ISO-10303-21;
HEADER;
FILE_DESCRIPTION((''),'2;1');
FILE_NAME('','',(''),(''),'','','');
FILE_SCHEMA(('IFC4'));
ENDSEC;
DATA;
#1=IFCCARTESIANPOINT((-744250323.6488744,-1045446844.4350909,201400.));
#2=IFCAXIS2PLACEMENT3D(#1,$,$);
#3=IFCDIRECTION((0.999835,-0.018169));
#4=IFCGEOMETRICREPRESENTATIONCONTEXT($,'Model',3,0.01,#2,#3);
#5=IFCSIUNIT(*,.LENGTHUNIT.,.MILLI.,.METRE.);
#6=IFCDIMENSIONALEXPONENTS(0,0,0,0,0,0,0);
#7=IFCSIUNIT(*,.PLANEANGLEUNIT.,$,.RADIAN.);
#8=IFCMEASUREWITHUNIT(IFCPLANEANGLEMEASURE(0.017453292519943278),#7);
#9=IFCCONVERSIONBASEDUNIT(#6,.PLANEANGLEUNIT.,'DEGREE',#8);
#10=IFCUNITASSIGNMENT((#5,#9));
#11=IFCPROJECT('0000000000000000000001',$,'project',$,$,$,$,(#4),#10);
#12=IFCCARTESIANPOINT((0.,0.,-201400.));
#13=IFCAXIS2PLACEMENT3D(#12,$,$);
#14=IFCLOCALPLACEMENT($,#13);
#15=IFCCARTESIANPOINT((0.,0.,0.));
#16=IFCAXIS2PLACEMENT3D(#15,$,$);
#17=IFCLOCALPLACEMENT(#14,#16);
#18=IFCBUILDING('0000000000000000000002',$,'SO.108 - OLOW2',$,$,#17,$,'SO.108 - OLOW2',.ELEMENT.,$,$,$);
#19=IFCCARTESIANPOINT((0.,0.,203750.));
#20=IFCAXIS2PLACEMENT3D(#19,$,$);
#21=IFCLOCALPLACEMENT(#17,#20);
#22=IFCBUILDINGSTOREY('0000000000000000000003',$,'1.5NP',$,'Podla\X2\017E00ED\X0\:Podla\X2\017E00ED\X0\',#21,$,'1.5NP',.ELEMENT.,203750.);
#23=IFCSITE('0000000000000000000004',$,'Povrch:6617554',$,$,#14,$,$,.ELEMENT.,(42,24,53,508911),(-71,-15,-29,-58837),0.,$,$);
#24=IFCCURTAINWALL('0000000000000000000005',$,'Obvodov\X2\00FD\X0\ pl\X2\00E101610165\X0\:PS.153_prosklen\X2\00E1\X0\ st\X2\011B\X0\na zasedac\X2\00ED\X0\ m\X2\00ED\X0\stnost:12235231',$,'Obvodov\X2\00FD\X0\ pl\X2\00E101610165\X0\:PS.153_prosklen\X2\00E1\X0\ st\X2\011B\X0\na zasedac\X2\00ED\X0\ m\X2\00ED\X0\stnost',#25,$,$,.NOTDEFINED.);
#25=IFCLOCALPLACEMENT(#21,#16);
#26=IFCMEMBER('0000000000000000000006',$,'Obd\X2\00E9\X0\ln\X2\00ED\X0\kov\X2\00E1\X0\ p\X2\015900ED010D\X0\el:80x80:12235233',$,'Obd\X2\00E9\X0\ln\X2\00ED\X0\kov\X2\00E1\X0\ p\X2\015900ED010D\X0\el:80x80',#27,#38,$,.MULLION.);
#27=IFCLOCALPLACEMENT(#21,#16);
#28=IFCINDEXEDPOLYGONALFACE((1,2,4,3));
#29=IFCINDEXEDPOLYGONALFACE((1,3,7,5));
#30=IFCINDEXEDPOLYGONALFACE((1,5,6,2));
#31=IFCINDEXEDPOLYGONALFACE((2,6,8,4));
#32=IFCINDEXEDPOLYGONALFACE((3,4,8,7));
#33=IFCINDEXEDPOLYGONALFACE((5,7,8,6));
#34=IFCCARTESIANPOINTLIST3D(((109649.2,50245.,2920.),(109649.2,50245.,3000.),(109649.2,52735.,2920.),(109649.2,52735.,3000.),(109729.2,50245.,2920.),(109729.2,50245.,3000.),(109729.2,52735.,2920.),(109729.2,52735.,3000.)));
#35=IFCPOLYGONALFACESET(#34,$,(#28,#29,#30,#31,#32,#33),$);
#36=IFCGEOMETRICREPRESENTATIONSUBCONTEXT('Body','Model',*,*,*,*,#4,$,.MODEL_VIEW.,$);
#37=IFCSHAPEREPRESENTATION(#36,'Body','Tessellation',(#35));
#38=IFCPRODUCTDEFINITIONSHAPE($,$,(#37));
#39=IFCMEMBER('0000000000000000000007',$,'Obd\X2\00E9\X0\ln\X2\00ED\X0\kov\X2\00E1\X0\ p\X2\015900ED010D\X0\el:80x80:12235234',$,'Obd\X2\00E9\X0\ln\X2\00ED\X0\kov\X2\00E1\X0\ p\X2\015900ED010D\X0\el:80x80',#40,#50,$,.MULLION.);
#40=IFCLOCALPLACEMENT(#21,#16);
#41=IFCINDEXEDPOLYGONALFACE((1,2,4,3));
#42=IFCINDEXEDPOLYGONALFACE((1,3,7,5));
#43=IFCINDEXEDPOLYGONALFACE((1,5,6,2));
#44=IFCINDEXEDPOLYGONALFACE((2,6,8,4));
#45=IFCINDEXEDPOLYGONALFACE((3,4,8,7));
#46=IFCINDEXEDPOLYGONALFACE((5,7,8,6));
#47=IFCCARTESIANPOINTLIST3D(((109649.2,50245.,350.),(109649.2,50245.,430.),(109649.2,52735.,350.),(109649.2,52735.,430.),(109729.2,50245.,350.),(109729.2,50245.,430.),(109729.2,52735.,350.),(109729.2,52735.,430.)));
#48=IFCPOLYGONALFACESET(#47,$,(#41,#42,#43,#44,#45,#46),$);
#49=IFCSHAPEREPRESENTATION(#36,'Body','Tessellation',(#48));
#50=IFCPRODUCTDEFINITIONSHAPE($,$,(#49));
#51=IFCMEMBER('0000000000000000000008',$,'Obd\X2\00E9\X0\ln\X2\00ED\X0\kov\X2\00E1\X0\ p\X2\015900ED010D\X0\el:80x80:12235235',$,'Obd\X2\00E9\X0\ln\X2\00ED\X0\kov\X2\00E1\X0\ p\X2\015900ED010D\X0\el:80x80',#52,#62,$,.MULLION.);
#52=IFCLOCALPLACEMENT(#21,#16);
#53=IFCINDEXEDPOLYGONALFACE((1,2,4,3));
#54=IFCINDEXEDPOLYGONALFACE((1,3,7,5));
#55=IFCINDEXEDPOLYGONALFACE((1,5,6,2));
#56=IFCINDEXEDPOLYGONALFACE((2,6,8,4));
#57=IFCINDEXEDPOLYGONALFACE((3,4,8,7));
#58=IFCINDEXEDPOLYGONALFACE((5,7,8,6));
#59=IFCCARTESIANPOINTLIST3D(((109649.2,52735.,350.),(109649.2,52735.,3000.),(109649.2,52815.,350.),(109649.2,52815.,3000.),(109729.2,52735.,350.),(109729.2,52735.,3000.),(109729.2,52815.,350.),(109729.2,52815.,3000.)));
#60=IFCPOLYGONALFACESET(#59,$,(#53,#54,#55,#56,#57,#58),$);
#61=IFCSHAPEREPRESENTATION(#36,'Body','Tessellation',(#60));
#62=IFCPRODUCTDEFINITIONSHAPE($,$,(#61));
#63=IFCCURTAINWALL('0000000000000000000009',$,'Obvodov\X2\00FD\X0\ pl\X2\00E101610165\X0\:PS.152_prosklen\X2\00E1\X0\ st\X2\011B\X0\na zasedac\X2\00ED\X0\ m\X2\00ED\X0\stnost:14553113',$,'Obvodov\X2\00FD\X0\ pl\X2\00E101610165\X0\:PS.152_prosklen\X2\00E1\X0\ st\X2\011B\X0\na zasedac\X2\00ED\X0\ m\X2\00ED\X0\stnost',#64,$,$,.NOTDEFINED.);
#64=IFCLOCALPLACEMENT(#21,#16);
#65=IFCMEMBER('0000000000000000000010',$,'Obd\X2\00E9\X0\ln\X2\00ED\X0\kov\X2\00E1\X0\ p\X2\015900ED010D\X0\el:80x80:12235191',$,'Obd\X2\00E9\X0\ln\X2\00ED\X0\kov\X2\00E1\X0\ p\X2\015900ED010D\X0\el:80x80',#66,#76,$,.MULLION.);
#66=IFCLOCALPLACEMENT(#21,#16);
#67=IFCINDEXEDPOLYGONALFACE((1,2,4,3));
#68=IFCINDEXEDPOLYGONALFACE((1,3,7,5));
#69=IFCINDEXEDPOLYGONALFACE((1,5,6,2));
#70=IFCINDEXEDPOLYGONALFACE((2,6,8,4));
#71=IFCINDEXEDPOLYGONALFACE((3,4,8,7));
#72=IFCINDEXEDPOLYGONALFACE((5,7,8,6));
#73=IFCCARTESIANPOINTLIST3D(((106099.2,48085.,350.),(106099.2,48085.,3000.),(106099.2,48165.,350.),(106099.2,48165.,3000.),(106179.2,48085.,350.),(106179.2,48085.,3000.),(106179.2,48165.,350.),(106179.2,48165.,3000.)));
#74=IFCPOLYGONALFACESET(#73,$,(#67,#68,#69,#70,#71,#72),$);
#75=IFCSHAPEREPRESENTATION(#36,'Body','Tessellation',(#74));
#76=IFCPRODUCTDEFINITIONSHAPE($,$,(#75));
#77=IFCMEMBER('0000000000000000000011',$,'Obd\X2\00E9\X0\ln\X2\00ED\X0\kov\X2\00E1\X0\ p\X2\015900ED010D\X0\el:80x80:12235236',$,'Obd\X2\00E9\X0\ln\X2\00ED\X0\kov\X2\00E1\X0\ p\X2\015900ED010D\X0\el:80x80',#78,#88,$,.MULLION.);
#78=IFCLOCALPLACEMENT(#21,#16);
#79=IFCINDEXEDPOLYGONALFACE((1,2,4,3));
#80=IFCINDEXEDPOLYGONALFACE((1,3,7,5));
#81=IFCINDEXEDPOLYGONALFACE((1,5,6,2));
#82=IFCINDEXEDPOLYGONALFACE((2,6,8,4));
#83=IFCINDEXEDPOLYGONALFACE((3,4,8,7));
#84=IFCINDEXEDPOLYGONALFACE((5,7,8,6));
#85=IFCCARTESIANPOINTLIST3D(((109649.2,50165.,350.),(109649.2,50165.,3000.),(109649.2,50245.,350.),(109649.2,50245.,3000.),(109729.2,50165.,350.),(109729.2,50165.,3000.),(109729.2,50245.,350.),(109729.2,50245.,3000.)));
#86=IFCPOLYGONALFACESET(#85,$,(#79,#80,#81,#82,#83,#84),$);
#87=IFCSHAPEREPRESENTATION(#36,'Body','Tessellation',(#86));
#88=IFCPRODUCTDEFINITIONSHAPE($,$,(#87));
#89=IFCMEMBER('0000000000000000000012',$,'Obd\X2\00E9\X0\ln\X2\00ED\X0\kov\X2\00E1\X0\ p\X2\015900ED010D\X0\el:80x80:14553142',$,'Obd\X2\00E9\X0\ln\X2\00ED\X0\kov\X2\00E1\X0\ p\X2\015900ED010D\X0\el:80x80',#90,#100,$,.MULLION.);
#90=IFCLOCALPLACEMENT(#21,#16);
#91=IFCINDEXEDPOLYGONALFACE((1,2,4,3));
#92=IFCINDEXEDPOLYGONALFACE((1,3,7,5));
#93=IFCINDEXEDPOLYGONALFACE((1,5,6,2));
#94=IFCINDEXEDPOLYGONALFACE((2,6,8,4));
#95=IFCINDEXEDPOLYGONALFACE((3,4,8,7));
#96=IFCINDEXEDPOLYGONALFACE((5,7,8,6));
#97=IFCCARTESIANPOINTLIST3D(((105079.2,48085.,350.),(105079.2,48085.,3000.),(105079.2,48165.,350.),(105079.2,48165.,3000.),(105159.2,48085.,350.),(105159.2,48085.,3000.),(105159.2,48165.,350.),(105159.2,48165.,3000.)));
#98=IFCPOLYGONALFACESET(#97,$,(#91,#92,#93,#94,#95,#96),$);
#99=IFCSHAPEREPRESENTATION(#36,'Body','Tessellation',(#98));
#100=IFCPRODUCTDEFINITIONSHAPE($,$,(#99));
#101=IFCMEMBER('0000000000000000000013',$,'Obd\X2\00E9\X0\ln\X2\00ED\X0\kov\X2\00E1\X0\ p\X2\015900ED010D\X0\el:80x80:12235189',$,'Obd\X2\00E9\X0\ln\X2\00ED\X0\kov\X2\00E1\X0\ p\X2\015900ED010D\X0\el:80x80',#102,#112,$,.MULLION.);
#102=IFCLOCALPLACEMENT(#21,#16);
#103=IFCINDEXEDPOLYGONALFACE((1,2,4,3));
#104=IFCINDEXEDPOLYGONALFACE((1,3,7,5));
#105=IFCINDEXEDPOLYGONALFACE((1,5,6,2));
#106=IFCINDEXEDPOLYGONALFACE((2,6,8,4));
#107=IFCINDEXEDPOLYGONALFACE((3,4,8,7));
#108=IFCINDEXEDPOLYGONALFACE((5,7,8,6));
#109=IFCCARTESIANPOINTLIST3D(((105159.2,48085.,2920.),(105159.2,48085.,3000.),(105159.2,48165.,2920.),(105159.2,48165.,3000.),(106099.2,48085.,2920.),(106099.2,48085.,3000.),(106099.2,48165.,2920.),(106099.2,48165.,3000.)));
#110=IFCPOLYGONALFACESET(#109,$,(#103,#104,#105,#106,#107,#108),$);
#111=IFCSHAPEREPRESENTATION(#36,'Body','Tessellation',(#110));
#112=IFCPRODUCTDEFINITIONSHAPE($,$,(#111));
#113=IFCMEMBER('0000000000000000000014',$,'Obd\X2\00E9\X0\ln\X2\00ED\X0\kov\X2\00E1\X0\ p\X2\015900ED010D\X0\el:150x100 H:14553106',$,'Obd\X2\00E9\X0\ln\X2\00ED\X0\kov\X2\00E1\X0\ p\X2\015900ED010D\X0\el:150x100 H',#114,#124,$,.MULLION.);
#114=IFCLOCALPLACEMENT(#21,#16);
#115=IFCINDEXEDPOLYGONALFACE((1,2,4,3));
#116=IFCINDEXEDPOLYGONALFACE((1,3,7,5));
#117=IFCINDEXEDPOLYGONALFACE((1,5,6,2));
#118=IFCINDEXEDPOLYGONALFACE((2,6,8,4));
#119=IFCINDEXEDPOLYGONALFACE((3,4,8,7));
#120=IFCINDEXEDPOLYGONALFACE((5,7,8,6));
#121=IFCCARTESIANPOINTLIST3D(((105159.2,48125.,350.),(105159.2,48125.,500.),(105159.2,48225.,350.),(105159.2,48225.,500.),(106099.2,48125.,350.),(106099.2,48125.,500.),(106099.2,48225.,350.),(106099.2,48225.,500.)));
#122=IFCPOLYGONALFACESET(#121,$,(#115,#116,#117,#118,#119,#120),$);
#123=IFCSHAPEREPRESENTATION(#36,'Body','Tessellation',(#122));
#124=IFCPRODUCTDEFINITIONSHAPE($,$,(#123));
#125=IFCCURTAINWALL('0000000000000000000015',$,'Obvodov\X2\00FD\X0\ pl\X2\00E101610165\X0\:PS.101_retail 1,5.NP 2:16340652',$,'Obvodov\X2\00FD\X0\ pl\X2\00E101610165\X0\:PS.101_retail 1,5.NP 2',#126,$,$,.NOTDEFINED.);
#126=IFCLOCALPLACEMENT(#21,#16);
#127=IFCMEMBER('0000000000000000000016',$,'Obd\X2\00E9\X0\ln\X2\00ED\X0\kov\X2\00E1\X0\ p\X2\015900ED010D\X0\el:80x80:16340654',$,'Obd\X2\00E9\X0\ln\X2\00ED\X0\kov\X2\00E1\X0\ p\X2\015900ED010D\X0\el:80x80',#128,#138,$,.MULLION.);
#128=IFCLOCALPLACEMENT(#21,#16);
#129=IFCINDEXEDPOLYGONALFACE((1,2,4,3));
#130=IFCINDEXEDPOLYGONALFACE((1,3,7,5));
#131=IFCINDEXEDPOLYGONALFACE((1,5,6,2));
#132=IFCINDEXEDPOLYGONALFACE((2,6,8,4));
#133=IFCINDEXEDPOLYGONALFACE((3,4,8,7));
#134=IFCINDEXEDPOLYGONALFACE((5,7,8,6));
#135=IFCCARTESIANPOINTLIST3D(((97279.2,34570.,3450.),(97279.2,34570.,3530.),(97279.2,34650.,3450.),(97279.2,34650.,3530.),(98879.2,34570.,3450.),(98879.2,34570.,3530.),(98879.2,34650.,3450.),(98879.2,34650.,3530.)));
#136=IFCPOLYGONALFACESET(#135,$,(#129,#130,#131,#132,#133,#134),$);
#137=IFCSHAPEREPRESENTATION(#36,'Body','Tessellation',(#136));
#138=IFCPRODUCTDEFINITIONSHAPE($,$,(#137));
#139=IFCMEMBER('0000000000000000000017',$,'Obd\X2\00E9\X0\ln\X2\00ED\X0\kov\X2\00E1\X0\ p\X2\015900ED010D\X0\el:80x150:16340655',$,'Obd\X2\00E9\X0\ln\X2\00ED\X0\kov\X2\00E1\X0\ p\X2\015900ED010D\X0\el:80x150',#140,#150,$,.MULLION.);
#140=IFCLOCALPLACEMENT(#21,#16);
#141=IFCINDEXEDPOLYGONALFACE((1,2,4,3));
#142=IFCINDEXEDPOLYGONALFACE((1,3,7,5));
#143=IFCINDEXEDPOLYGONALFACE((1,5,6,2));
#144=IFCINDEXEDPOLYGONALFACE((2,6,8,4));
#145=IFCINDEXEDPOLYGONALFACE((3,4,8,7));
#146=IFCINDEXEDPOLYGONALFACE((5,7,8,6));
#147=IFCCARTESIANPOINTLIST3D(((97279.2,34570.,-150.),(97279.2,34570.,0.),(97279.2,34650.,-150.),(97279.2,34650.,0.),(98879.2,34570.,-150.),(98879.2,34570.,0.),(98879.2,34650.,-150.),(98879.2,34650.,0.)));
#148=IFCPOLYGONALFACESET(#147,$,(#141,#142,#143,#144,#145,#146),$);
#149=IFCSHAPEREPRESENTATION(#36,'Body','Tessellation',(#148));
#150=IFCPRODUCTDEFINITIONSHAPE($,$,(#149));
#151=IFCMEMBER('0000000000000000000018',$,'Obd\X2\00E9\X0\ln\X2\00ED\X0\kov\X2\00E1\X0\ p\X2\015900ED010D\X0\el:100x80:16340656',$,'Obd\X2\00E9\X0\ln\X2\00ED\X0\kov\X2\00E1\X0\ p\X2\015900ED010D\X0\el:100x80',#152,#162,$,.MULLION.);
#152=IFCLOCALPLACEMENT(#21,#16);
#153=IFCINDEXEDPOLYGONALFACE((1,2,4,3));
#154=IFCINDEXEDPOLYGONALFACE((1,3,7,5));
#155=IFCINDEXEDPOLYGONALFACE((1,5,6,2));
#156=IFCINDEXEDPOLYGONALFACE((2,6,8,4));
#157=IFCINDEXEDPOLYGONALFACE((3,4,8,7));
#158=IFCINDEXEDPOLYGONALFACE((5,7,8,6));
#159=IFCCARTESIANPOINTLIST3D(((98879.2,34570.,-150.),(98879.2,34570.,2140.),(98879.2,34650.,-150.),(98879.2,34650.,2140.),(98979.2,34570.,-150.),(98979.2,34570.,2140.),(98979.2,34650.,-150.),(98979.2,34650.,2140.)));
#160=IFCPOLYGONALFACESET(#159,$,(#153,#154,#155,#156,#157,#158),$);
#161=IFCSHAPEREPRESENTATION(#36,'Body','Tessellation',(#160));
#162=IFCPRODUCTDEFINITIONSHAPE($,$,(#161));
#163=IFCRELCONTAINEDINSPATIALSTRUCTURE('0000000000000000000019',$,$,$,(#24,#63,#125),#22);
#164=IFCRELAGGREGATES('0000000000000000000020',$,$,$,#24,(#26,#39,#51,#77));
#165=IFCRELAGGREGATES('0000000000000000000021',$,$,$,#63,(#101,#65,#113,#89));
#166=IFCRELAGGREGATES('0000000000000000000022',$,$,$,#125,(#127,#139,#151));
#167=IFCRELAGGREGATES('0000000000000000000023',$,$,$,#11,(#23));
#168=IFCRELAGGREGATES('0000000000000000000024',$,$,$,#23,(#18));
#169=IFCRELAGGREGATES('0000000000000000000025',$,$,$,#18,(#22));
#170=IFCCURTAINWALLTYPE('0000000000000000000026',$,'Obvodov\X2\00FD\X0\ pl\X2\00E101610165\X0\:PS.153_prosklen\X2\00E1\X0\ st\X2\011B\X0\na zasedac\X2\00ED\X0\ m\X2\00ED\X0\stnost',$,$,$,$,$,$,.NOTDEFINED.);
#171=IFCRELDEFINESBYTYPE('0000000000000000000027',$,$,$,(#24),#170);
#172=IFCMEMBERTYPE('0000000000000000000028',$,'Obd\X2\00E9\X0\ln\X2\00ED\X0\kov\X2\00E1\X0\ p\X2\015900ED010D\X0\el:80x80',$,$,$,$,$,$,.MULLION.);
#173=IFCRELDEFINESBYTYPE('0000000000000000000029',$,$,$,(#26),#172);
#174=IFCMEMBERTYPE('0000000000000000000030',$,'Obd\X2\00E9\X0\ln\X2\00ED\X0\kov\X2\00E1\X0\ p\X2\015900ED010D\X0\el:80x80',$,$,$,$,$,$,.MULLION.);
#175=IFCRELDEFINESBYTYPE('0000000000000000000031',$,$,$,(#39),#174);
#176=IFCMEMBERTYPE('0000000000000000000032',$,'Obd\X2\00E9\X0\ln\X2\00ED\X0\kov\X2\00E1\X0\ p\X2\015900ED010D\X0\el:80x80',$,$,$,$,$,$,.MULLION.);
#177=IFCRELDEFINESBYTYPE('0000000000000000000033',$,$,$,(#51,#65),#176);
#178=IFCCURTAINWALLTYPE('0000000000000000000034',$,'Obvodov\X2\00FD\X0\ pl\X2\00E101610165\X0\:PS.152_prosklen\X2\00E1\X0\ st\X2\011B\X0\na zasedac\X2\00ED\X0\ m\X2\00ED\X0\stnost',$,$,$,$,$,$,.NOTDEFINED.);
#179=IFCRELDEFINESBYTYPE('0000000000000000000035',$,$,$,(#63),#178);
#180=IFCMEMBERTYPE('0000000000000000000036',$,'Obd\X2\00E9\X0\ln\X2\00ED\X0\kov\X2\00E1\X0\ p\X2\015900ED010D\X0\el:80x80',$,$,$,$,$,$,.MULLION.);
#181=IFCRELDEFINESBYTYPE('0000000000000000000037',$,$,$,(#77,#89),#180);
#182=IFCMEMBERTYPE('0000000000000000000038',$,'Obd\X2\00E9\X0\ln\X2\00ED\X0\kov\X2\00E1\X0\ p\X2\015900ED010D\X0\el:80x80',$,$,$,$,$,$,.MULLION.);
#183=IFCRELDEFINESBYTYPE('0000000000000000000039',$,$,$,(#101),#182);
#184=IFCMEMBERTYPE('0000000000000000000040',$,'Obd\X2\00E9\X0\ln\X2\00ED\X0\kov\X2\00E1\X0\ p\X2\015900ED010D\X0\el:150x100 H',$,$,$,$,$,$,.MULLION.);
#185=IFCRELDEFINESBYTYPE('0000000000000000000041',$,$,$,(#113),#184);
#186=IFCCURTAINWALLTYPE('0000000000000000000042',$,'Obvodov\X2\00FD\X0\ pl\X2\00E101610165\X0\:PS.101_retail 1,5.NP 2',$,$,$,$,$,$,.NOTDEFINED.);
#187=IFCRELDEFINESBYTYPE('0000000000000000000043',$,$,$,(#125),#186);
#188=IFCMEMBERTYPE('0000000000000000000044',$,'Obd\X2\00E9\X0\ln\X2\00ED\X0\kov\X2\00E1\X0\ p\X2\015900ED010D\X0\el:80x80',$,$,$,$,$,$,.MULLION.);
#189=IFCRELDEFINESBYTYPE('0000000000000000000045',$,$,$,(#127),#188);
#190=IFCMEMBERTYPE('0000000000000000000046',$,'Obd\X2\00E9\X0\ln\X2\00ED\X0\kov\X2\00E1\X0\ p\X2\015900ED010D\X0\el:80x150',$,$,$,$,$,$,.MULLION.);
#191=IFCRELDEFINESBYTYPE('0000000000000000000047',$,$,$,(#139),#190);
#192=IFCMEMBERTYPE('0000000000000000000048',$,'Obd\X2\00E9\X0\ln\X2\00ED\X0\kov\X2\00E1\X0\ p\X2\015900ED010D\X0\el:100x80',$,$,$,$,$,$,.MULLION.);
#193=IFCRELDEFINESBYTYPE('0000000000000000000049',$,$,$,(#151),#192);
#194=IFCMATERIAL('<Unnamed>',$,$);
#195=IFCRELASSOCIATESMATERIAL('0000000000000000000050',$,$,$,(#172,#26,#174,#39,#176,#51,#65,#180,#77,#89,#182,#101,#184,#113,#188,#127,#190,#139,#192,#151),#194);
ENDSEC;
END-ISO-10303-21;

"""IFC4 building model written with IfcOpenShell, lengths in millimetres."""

from ifc_helpers import new_model, entity, si_unit, converted_unit, direction, frame, origin, place, context, subcontext, project, spatial, indexed_curve, outline, extrude, source, transform, mapped, material, type_object, type_shapes, element, aggregate, save


model = new_model("IFC4")

# Units and contexts
model_context = context("Model", 3, precision=0.01, world=frame((-744250323.6488744, -1045446844.4350909, 201400.0)), true_north=direction((0.999835, -0.018169)))
body_context = subcontext(model_context, "Body", "Model", "MODEL_VIEW")
ifc_project = project(units=[si_unit("LENGTHUNIT", "METRE", prefix="MILLI"), converted_unit("PLANEANGLEUNIT", "DEGREE", entity("IfcPlaneAngleMeasure", 0.017453292519943278), si_unit("PLANEANGLEUNIT", "RADIAN"), dimensions=[0, 0, 0, 0, 0, 0, 0])], contexts=[model_context])

# Site, building, storey
site_placement = place(None, frame((0.0, 0.0, -201400.0)))
site = spatial("IfcSite", under=ifc_project, at=site_placement, Name="Povrch:6617554", CompositionType="ELEMENT", RefLatitude=(42, 24, 53, 508911), RefLongitude=(-71, -15, -29, -58837), RefElevation=0.0)
building_placement = place(site_placement, origin())
building = spatial("IfcBuilding", under=site, at=building_placement, Name="SO.108 - OLOW2", LongName="SO.108 - OLOW2", CompositionType="ELEMENT")
storey_placement = place(building_placement, frame((0.0, 0.0, 203750.0)))
storey = spatial("IfcBuildingStorey", under=building, at=storey_placement, Name="1.5NP", ObjectType="Podlaží:Podlaží", LongName="1.5NP", CompositionType="ELEMENT", Elevation=203750.0)

# Curtain wall, members
curtain_wall_type_1 = type_object("IfcCurtainWallType", Name="Obvodový plášť:PS.153_prosklená stěna zasedací místnost", PredefinedType="NOTDEFINED")
curtain_wall_1_placement = place(storey_placement, frame((0.0, 0.0, -203750.0)))
curtain_wall_1 = element("IfcCurtainWall", 1, at=curtain_wall_1_placement, inside=storey, type_object=curtain_wall_type_1, Name="Obvodový plášť:PS.153_prosklená stěna zasedací místnost:12235231", ObjectType="Obvodový plášť:PS.153_prosklená stěna zasedací místnost", PredefinedType="NOTDEFINED")
ifc_material_1 = material(Name="<Unnamed>")
member_type_1 = type_object("IfcMemberType", Name="Obdélníková příčel:80x80", PredefinedType="MULLION", material=ifc_material_1)
shared_shape_1 = source(origin(), body_context, "Body", "SweptSolid", [
    extrude(outline(indexed_curve([(-40.0, -40.0), (40.0, -40.0), (40.0, 40.0), (-40.0, 40.0), (-40.0, -40.0)], self_intersect=False)), frame((-40.0, 0.0, -2490.0), z_axis=(0.0, 0.0, 1.0), x_axis=(-1.0, 0.0, 0.0)), (0.0, 0.0, 1.0), 2490.0),
])
type_shapes(member_type_1, [shared_shape_1])
member_1_placement = place(curtain_wall_1_placement, frame((109689.2, 52735.0, 206750.0), z_axis=(0.0, 1.0, 0.0), x_axis=(0.0, 0.0, 1.0)))
member_1 = element("IfcMember", 2, at=member_1_placement, type_object=member_type_1, material=ifc_material_1, Name="Obdélníková příčel:80x80:12235233", ObjectType="Obdélníková příčel:80x80", PredefinedType="MULLION", context=body_context, shape_type="MappedRepresentation", body=[
    mapped(shared_shape_1, transform((0.0, 0.0, 0.0), scale=1.0)),
])
member_type_2 = type_object("IfcMemberType", Name="Obdélníková příčel:80x80", PredefinedType="MULLION", material=ifc_material_1)
shared_shape_2 = source(origin(), body_context, "Body", "SweptSolid", [
    extrude(outline(indexed_curve([(-40.0, -40.0), (40.0, -40.0), (40.0, 40.0), (-40.0, 40.0), (-40.0, -40.0)], self_intersect=False)), frame((-40.0, 0.0, -2490.0), z_axis=(0.0, 0.0, 1.0), x_axis=(-1.0, 0.0, 0.0)), (0.0, 0.0, 1.0), 2490.0),
])
type_shapes(member_type_2, [shared_shape_2])
member_2_placement = place(curtain_wall_1_placement, frame((109689.2, 50245.0, 204100.0), z_axis=(0.0, -1.0, 0.0), x_axis=(0.0, 0.0, -1.0)))
member_2 = element("IfcMember", 3, at=member_2_placement, type_object=member_type_2, material=ifc_material_1, Name="Obdélníková příčel:80x80:12235234", ObjectType="Obdélníková příčel:80x80", PredefinedType="MULLION", context=body_context, shape_type="MappedRepresentation", body=[
    mapped(shared_shape_2, transform((0.0, 0.0, 0.0), scale=1.0)),
])
member_type_3 = type_object("IfcMemberType", Name="Obdélníková příčel:80x80", PredefinedType="MULLION", material=ifc_material_1)
shared_shape_3 = source(origin(), body_context, "Body", "SweptSolid", [
    extrude(outline(indexed_curve([(-40.0, -40.0), (40.0, -40.0), (40.0, 40.0), (-40.0, 40.0), (-40.0, -40.0)], self_intersect=False)), frame((-40.0, 0.0, -2650.0), z_axis=(0.0, 0.0, 1.0), x_axis=(-1.0, 0.0, 0.0)), (0.0, 0.0, 1.0), 2650.0),
])
type_shapes(member_type_3, [shared_shape_3])
member_3_placement = place(curtain_wall_1_placement, frame((109689.2, 52815.0, 204100.0), z_axis=(0.0, 0.0, -1.0), x_axis=(0.0, 1.0, 0.0)))
member_3 = element("IfcMember", 4, at=member_3_placement, type_object=member_type_3, material=ifc_material_1, Name="Obdélníková příčel:80x80:12235235", ObjectType="Obdélníková příčel:80x80", PredefinedType="MULLION", context=body_context, shape_type="MappedRepresentation", body=[
    mapped(shared_shape_3, transform((0.0, 0.0, 0.0), scale=1.0)),
])

# Curtain wall, member
curtain_wall_type_2 = type_object("IfcCurtainWallType", Name="Obvodový plášť:PS.152_prosklená stěna zasedací místnost", PredefinedType="NOTDEFINED")
curtain_wall_2_placement = place(storey_placement, frame((0.0, 0.0, -203750.0)))
curtain_wall_2 = element("IfcCurtainWall", 5, at=curtain_wall_2_placement, inside=storey, type_object=curtain_wall_type_2, Name="Obvodový plášť:PS.152_prosklená stěna zasedací místnost:14553113", ObjectType="Obvodový plášť:PS.152_prosklená stěna zasedací místnost", PredefinedType="NOTDEFINED")
member_4_placement = place(curtain_wall_2_placement, frame((106179.2, 48125.0, 204100.0), z_axis=(0.0, 0.0, -1.0), x_axis=(1.0, 0.0, 0.0)))
member_4 = element("IfcMember", 6, at=member_4_placement, type_object=member_type_3, material=ifc_material_1, Name="Obdélníková příčel:80x80:12235191", ObjectType="Obdélníková příčel:80x80", PredefinedType="MULLION", context=body_context, shape_type="MappedRepresentation", body=[
    mapped(shared_shape_3, transform((0.0, 0.0, 0.0), scale=1.0)),
])

# Members
member_type_4 = type_object("IfcMemberType", Name="Obdélníková příčel:80x80", PredefinedType="MULLION", material=ifc_material_1)
shared_shape_4 = source(origin(), body_context, "Body", "SweptSolid", [
    extrude(outline(indexed_curve([(-40.0, -40.0), (40.0, -40.0), (40.0, 40.0), (-40.0, 40.0), (-40.0, -40.0)], self_intersect=False)), frame((-40.0, 0.0, -2650.0), z_axis=(0.0, 0.0, 1.0), x_axis=(-1.0, 0.0, 0.0)), (0.0, 0.0, 1.0), 2650.0),
])
type_shapes(member_type_4, [shared_shape_4])
member_5_placement = place(curtain_wall_1_placement, frame((109689.2, 50165.0, 206750.0), z_axis=(0.0, 0.0, 1.0), x_axis=(0.0, -1.0, 0.0)))
member_5 = element("IfcMember", 7, at=member_5_placement, type_object=member_type_4, material=ifc_material_1, Name="Obdélníková příčel:80x80:12235236", ObjectType="Obdélníková příčel:80x80", PredefinedType="MULLION", context=body_context, shape_type="MappedRepresentation", body=[
    mapped(shared_shape_4, transform((0.0, 0.0, 0.0), scale=1.0)),
])
member_6_placement = place(curtain_wall_2_placement, frame((105079.2, 48125.0, 206750.0), z_axis=(0.0, 0.0, 1.0), x_axis=(-1.0, 0.0, 0.0)))
member_6 = element("IfcMember", 8, at=member_6_placement, type_object=member_type_4, material=ifc_material_1, Name="Obdélníková příčel:80x80:14553142", ObjectType="Obdélníková příčel:80x80", PredefinedType="MULLION", context=body_context, shape_type="MappedRepresentation", body=[
    mapped(shared_shape_4, transform((0.0, 0.0, 0.0), scale=1.0)),
])
member_type_5 = type_object("IfcMemberType", Name="Obdélníková příčel:80x80", PredefinedType="MULLION", material=ifc_material_1)
shared_shape_5 = source(origin(), body_context, "Body", "SweptSolid", [
    extrude(outline(indexed_curve([(-40.0, -40.0), (40.0, -40.0), (40.0, 40.0), (-40.0, 40.0), (-40.0, -40.0)], self_intersect=False)), frame((-40.0, 0.0, -940.0), z_axis=(0.0, 0.0, 1.0), x_axis=(-1.0, 0.0, 0.0)), (0.0, 0.0, 1.0), 940.0),
])
type_shapes(member_type_5, [shared_shape_5])
member_7_placement = place(curtain_wall_2_placement, frame((106099.2, 48125.0, 206750.0), z_axis=(1.0, 0.0, 0.0), x_axis=(0.0, 0.0, 1.0)))
member_7 = element("IfcMember", 9, at=member_7_placement, type_object=member_type_5, material=ifc_material_1, Name="Obdélníková příčel:80x80:12235189", ObjectType="Obdélníková příčel:80x80", PredefinedType="MULLION", context=body_context, shape_type="MappedRepresentation", body=[
    mapped(shared_shape_5, transform((0.0, 0.0, 0.0), scale=1.0)),
])
member_type_6 = type_object("IfcMemberType", Name="Obdélníková příčel:150x100 H", PredefinedType="MULLION", material=ifc_material_1)
shared_shape_6 = source(origin(), body_context, "Body", "SweptSolid", [
    extrude(outline(indexed_curve([(-75.0, -50.0), (75.0, -50.0), (75.0, 50.0), (-75.0, 50.0), (-75.0, -50.0)], self_intersect=False)), frame((-75.0, -50.0, -940.0), z_axis=(0.0, 0.0, 1.0), x_axis=(-1.0, 0.0, 0.0)), (0.0, 0.0, 1.0), 940.0),
])
type_shapes(member_type_6, [shared_shape_6])
member_8_placement = place(curtain_wall_2_placement, frame((105159.2, 48125.0, 204100.0), z_axis=(-1.0, 0.0, 0.0), x_axis=(0.0, 0.0, -1.0)))
member_8 = element("IfcMember", 10, at=member_8_placement, type_object=member_type_6, material=ifc_material_1, Name="Obdélníková příčel:150x100 H:14553106", ObjectType="Obdélníková příčel:150x100 H", PredefinedType="MULLION", context=body_context, shape_type="MappedRepresentation", body=[
    mapped(shared_shape_6, transform((0.0, 0.0, 0.0), scale=1.0)),
])

# Curtain wall, members
curtain_wall_type_3 = type_object("IfcCurtainWallType", Name="Obvodový plášť:PS.101_retail 1,5.NP 2", PredefinedType="NOTDEFINED")
curtain_wall_3_placement = place(storey_placement, frame((0.0, 0.0, -203750.0)))
curtain_wall_3 = element("IfcCurtainWall", 11, at=curtain_wall_3_placement, inside=storey, type_object=curtain_wall_type_3, Name="Obvodový plášť:PS.101_retail 1,5.NP 2:16340652", ObjectType="Obvodový plášť:PS.101_retail 1,5.NP 2", PredefinedType="NOTDEFINED")
member_type_7 = type_object("IfcMemberType", Name="Obdélníková příčel:80x80", PredefinedType="MULLION", material=ifc_material_1)
shared_shape_7 = source(origin(), body_context, "Body", "SweptSolid", [
    extrude(outline(indexed_curve([(-40.0, -40.0), (40.0, -40.0), (40.0, 40.0), (-40.0, 40.0), (-40.0, -40.0)], self_intersect=False)), frame((-40.0, 0.0, -1600.0), z_axis=(0.0, 0.0, 1.0), x_axis=(-1.0, 0.0, 0.0)), (0.0, 0.0, 1.0), 1600.0),
])
type_shapes(member_type_7, [shared_shape_7])
member_9_placement = place(curtain_wall_3_placement, frame((98879.2, 34610.0, 207280.0), z_axis=(1.0, 0.0, 0.0), x_axis=(0.0, 0.0, 1.0)))
member_9 = element("IfcMember", 12, at=member_9_placement, type_object=member_type_7, material=ifc_material_1, Name="Obdélníková příčel:80x80:16340654", ObjectType="Obdélníková příčel:80x80", PredefinedType="MULLION", context=body_context, shape_type="MappedRepresentation", body=[
    mapped(shared_shape_7, transform((0.0, 0.0, 0.0), scale=1.0)),
])
member_type_8 = type_object("IfcMemberType", Name="Obdélníková příčel:80x150", PredefinedType="MULLION", material=ifc_material_1)
shared_shape_8 = source(origin(), body_context, "Body", "SweptSolid", [
    extrude(outline(indexed_curve([(-75.0, -40.0), (75.0, -40.0), (75.0, 40.0), (-75.0, 40.0), (-75.0, -40.0)], self_intersect=False)), frame((-75.0, 0.0, -1600.0), z_axis=(0.0, 0.0, 1.0), x_axis=(-1.0, 0.0, 0.0)), (0.0, 0.0, 1.0), 1600.0),
])
type_shapes(member_type_8, [shared_shape_8])
member_10_placement = place(curtain_wall_3_placement, frame((97279.2, 34610.0, 203600.0), z_axis=(-1.0, 0.0, 0.0), x_axis=(0.0, 0.0, -1.0)))
member_10 = element("IfcMember", 13, at=member_10_placement, type_object=member_type_8, material=ifc_material_1, Name="Obdélníková příčel:80x150:16340655", ObjectType="Obdélníková příčel:80x150", PredefinedType="MULLION", context=body_context, shape_type="MappedRepresentation", body=[
    mapped(shared_shape_8, transform((0.0, 0.0, 0.0), scale=1.0)),
])
member_type_9 = type_object("IfcMemberType", Name="Obdélníková příčel:100x80", PredefinedType="MULLION", material=ifc_material_1)
shared_shape_9 = source(origin(), body_context, "Body", "SweptSolid", [
    extrude(outline(indexed_curve([(-50.0, -40.0), (50.0, -40.0), (50.0, 40.0), (-50.0, 40.0), (-50.0, -40.0)], self_intersect=False)), frame((-50.0, 0.0, -2290.0), z_axis=(0.0, 0.0, 1.0), x_axis=(-1.0, 0.0, 0.0)), (0.0, 0.0, 1.0), 2290.0),
])
type_shapes(member_type_9, [shared_shape_9])
member_11_placement = place(curtain_wall_3_placement, frame((98979.2, 34610.0, 203600.0), z_axis=(0.0, 0.0, -1.0), x_axis=(1.0, 0.0, 0.0)))
member_11 = element("IfcMember", 14, at=member_11_placement, type_object=member_type_9, material=ifc_material_1, Name="Obdélníková příčel:100x80:16340656", ObjectType="Obdélníková příčel:100x80", PredefinedType="MULLION", context=body_context, shape_type="MappedRepresentation", body=[
    mapped(shared_shape_9, transform((0.0, 0.0, 0.0), scale=1.0)),
])

aggregate(curtain_wall_1, [member_1, member_2, member_3, member_5])
aggregate(curtain_wall_2, [member_7, member_4, member_8, member_6])

aggregate(curtain_wall_3, [member_9, member_10, member_11])

save(model, "model.ifc")
